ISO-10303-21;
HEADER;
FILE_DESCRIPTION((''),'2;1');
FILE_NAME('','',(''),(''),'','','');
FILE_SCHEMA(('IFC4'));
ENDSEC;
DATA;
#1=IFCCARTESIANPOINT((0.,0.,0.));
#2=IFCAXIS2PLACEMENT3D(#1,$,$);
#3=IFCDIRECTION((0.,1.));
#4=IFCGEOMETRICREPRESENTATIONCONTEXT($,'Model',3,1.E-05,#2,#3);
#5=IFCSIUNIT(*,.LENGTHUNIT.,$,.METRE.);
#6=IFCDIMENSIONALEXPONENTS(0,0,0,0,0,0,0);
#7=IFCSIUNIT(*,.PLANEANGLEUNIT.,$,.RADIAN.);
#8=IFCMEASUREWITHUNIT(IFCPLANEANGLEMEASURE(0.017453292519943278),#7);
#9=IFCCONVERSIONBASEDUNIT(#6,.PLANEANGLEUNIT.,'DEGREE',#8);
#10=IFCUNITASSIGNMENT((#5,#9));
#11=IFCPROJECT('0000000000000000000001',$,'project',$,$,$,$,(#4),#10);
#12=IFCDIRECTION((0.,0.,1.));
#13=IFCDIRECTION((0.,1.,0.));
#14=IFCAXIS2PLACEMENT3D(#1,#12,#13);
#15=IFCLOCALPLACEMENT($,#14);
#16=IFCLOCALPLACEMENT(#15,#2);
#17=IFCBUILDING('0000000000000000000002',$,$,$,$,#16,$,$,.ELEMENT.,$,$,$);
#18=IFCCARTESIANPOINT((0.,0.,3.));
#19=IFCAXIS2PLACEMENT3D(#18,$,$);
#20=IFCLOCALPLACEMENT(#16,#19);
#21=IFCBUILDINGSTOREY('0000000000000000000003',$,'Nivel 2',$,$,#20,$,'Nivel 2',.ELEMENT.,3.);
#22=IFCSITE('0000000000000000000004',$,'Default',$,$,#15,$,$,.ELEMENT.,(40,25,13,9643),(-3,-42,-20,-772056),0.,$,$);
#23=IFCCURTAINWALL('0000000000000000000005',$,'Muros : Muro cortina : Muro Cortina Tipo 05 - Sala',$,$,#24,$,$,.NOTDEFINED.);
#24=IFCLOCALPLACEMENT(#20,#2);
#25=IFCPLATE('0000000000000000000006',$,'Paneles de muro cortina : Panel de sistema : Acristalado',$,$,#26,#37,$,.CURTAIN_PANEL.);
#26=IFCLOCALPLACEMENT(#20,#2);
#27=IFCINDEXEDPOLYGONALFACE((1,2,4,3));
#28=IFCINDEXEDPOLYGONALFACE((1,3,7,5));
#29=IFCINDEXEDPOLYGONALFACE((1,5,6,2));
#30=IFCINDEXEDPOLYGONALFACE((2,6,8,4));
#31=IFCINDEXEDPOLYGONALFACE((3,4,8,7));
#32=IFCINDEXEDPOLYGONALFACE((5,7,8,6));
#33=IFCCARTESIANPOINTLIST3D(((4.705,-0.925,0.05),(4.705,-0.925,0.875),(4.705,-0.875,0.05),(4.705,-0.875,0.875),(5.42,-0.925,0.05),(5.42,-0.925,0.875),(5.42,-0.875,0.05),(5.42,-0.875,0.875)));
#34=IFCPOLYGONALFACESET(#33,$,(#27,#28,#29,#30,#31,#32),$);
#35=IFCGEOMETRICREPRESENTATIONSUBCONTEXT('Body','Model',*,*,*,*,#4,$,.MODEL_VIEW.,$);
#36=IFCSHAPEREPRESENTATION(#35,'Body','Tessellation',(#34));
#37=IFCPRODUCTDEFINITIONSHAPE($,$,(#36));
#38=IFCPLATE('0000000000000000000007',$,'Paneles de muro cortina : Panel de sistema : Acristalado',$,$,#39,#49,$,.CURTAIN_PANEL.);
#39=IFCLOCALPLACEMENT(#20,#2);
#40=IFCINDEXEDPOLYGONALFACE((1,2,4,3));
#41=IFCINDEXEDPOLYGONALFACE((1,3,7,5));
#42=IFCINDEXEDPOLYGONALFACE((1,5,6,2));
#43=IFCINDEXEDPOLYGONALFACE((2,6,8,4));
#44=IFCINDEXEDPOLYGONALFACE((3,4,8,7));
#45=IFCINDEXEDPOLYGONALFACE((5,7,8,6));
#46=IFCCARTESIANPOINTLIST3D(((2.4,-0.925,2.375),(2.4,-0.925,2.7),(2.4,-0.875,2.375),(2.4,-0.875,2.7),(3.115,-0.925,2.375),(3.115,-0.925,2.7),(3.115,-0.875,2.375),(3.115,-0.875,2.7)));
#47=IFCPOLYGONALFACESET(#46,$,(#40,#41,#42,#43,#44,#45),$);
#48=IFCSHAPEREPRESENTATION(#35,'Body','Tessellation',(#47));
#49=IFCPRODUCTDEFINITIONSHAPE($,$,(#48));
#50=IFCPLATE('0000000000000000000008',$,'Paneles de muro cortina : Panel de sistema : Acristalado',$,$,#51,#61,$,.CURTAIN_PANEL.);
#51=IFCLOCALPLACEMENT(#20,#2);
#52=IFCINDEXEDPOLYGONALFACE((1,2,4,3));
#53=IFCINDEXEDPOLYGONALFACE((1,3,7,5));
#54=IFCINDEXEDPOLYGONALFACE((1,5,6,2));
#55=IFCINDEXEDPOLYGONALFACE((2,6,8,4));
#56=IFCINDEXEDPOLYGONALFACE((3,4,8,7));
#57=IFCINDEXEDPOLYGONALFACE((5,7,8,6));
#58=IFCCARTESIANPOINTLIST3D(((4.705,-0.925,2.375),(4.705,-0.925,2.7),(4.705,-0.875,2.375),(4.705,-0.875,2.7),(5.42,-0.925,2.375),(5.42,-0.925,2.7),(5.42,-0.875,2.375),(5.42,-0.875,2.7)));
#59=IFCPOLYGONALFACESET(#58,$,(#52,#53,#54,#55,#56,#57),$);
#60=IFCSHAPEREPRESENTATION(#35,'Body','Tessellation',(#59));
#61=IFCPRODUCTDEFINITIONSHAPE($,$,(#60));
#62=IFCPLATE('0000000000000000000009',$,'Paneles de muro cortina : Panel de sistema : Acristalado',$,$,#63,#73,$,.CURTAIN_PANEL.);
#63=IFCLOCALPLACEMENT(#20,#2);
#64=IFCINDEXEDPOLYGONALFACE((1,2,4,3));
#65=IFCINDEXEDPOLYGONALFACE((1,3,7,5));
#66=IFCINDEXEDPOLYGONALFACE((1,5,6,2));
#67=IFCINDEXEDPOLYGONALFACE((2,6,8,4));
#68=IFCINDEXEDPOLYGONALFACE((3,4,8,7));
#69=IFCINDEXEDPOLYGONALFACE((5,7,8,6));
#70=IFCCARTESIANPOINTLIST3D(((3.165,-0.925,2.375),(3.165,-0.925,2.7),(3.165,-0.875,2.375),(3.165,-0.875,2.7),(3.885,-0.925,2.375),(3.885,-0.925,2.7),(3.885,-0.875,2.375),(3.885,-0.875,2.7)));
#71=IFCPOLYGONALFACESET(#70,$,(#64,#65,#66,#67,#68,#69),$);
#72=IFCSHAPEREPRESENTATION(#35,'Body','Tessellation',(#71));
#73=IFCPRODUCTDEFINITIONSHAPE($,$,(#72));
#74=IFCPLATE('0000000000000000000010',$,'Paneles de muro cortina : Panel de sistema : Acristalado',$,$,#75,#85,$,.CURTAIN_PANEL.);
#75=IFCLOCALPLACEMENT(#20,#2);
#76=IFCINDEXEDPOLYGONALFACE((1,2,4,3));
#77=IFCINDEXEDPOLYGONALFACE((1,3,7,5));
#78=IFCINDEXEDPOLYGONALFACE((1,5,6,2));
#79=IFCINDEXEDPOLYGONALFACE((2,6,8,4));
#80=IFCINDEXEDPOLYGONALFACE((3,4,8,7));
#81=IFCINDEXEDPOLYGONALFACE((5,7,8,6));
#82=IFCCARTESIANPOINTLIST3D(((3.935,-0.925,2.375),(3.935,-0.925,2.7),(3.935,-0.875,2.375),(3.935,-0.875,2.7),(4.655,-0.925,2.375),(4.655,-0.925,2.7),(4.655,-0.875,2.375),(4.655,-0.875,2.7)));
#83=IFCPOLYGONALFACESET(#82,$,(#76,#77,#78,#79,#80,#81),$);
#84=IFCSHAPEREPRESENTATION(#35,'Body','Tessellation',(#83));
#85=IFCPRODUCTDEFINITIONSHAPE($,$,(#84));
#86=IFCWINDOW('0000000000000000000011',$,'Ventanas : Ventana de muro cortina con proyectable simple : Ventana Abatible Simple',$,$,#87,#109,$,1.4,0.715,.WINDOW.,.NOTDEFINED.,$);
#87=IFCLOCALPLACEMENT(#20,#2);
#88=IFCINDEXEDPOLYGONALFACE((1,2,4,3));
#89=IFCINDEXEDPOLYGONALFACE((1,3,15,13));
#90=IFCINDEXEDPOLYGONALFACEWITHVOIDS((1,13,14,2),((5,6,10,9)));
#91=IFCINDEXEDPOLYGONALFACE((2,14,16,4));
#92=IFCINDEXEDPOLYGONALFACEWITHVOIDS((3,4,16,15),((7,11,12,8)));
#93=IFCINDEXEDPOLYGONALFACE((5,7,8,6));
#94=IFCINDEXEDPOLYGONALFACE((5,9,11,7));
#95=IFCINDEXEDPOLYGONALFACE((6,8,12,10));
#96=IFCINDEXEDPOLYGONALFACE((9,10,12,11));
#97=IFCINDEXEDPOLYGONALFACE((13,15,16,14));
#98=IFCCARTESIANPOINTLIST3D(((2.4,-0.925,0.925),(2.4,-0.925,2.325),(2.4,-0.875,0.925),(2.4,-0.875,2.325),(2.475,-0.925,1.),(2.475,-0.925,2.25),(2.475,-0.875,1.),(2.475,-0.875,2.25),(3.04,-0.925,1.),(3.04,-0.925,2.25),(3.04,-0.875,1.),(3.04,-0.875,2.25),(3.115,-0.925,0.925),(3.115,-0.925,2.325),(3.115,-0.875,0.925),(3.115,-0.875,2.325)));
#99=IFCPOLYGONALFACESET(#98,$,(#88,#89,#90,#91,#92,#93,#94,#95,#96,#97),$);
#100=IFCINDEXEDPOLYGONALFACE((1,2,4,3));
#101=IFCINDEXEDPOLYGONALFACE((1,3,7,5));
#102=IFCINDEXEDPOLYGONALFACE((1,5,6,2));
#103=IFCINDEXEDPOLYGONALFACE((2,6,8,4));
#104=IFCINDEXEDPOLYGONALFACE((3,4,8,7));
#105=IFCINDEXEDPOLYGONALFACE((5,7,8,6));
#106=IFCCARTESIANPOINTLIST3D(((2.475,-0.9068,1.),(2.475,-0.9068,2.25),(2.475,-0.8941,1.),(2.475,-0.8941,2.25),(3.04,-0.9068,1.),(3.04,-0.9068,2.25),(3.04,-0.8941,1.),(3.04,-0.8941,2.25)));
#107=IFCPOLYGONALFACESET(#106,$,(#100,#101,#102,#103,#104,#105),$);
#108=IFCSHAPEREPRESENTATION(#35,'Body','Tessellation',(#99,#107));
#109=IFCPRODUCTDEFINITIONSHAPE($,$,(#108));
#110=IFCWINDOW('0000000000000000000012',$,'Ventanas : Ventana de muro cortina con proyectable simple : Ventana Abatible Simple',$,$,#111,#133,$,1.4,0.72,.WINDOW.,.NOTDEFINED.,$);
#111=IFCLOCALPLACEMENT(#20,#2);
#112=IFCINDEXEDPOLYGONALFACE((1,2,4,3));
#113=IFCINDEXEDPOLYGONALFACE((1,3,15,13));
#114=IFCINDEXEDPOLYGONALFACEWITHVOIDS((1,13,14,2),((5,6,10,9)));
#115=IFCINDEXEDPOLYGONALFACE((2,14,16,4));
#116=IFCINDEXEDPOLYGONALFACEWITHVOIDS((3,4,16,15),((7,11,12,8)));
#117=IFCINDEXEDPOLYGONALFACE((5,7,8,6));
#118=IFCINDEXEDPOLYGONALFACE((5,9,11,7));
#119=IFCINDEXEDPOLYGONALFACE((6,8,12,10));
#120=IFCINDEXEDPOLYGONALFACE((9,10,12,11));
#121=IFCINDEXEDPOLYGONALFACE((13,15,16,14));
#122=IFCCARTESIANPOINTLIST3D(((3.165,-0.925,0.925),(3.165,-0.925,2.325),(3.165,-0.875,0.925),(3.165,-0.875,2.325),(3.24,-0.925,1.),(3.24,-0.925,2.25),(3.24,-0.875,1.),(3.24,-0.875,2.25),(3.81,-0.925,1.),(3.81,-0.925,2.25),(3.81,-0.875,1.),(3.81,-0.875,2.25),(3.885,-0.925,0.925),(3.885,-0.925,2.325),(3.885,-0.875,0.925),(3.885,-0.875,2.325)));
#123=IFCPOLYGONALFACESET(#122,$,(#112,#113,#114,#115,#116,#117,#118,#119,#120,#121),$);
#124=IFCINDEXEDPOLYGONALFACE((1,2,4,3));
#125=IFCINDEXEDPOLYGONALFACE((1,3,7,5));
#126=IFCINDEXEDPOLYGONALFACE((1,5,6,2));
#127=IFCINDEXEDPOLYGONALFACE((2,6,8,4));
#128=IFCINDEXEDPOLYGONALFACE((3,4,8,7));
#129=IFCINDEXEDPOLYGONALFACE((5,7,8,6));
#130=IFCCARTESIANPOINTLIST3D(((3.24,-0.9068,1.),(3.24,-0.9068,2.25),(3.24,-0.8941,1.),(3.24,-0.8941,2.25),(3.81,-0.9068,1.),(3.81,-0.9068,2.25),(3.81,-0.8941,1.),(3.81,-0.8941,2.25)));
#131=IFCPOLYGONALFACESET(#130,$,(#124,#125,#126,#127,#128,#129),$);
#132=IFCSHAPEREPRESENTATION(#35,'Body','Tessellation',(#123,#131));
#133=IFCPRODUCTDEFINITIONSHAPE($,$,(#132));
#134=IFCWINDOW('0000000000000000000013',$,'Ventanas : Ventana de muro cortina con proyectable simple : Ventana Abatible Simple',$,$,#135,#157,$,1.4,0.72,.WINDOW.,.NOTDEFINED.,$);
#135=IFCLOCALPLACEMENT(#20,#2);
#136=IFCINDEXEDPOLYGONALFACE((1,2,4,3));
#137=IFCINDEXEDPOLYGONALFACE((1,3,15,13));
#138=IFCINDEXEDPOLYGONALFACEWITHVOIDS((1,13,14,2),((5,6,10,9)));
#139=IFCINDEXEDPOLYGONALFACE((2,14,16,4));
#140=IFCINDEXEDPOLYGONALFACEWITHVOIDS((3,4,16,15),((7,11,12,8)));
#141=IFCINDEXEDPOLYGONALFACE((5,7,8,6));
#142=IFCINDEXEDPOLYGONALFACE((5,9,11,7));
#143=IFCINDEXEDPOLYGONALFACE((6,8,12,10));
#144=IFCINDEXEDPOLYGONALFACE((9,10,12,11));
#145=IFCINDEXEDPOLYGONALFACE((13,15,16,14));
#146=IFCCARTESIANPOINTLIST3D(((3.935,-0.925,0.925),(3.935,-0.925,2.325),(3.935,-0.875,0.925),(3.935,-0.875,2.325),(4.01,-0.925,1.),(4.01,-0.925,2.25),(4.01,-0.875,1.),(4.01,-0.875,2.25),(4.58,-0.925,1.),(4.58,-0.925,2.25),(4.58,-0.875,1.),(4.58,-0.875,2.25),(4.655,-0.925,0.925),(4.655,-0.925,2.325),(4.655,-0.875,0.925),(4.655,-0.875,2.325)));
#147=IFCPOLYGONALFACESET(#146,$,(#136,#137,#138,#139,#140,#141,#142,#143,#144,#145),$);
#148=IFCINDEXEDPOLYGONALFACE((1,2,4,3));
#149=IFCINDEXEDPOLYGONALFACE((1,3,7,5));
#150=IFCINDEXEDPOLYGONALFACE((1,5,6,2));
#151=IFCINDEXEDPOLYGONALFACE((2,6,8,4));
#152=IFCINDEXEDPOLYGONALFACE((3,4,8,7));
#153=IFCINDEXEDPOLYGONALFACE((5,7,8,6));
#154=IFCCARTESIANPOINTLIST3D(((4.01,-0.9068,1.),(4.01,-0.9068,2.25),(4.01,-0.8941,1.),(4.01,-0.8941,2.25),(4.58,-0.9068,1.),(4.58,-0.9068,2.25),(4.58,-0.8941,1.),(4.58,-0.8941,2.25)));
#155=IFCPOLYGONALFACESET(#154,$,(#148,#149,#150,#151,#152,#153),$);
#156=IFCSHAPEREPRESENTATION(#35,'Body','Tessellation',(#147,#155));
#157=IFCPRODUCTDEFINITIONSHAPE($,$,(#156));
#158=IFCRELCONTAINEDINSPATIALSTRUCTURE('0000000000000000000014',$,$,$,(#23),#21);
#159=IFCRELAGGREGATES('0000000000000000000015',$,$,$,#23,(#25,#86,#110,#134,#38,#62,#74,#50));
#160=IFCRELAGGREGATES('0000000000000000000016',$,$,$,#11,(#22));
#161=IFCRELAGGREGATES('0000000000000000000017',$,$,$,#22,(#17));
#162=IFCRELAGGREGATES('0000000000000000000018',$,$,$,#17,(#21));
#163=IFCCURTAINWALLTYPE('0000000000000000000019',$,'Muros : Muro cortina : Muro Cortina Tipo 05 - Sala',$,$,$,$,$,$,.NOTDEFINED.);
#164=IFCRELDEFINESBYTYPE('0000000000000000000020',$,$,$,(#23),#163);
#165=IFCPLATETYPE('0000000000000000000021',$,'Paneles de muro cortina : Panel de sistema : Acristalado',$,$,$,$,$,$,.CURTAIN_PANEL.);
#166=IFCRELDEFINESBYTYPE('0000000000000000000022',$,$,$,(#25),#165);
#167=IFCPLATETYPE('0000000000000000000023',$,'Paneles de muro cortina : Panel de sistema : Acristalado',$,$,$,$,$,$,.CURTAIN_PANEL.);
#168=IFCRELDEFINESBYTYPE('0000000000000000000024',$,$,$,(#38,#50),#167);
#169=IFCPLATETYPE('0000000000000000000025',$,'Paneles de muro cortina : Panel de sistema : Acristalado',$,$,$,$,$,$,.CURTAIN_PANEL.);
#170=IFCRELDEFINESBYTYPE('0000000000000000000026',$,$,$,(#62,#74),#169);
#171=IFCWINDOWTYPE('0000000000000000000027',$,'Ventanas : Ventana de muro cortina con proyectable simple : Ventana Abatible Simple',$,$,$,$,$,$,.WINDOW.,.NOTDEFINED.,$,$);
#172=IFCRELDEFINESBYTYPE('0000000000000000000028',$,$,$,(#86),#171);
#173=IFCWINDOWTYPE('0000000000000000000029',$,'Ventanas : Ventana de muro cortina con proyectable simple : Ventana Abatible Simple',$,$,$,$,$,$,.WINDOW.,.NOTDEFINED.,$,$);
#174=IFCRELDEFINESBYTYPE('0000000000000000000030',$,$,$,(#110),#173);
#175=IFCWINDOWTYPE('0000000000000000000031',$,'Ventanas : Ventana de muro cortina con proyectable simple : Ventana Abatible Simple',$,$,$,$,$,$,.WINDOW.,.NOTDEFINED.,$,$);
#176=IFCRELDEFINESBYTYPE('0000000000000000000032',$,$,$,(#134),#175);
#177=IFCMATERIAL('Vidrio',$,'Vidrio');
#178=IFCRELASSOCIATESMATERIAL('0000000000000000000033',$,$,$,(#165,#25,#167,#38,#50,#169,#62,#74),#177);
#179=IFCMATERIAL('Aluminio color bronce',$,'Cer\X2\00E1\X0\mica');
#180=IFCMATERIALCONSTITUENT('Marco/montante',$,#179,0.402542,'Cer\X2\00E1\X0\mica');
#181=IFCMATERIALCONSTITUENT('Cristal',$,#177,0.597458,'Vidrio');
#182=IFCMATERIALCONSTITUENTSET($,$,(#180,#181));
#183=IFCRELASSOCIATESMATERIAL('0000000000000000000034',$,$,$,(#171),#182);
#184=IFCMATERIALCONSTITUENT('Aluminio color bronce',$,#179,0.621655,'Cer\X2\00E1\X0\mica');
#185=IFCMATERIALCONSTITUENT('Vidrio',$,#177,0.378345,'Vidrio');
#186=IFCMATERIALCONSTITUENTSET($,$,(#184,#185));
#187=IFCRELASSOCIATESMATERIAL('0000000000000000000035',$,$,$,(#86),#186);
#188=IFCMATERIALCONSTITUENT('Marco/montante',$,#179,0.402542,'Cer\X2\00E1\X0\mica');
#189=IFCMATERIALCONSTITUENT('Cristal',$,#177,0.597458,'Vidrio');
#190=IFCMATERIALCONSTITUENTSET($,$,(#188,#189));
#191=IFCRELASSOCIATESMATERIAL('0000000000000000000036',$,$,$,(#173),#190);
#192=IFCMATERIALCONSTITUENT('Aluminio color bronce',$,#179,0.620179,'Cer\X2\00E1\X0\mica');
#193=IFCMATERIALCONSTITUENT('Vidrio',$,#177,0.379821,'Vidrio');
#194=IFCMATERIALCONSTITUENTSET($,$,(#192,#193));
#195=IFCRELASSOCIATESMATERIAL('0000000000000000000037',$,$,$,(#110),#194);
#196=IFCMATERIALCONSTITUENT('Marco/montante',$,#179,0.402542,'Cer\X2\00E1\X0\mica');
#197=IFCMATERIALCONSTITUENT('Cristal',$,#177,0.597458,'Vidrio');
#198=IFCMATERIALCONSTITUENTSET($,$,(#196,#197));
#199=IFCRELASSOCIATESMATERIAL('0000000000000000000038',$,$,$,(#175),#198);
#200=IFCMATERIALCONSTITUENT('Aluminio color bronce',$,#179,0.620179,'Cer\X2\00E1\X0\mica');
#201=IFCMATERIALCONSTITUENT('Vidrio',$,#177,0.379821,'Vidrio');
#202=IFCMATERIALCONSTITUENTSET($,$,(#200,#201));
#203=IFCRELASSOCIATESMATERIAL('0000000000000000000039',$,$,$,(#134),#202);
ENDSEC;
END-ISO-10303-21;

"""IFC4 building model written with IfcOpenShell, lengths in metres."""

from ifc_helpers import new_model, entity, si_unit, converted_unit, direction, frame, origin, place, context, subcontext, project, spatial, indexed_curve, outline, extrude, source, transform, mapped, material, constituent, constituent_set, type_object, type_shapes, element, aggregate, save


model = new_model("IFC4")

# Units and contexts
model_context = context("Model", 3, precision=1e-05, world=origin(), true_north=direction((0.0, 1.0)))
body_context = subcontext(model_context, "Body", "Model", "MODEL_VIEW")
ifc_project = project(units=[si_unit("LENGTHUNIT", "METRE"), converted_unit("PLANEANGLEUNIT", "DEGREE", entity("IfcPlaneAngleMeasure", 0.017453292519943278), si_unit("PLANEANGLEUNIT", "RADIAN"), dimensions=[0, 0, 0, 0, 0, 0, 0])], contexts=[model_context])

# Site, building, storey
site_placement = place(None, frame((0.0, 0.0, 0.0), z_axis=(0.0, 0.0, 1.0), x_axis=(0.0, 1.0, 0.0)))
site = spatial("IfcSite", under=ifc_project, at=site_placement, Name="Default", CompositionType="ELEMENT", RefLatitude=(40, 25, 13, 9643), RefLongitude=(-3, -42, -20, -772056), RefElevation=0.0)
building_placement = place(site_placement, origin())
building = spatial("IfcBuilding", under=site, at=building_placement, CompositionType="ELEMENT")
storey_placement = place(building_placement, frame((0.0, 0.0, 3.0)))
storey = spatial("IfcBuildingStorey", under=building, at=storey_placement, Name="Nivel 2", LongName="Nivel 2", CompositionType="ELEMENT", Elevation=3.0)

# Curtain wall, plates, windows
curtain_wall_type = type_object("IfcCurtainWallType", Name="Muros : Muro cortina : Muro Cortina Tipo 05 - Sala", PredefinedType="NOTDEFINED")
curtain_wall_placement = place(storey_placement, frame((0.0, 0.0, -3.0)))
curtain_wall = element("IfcCurtainWall", 1, at=curtain_wall_placement, inside=storey, type_object=curtain_wall_type, Name="Muros : Muro cortina : Muro Cortina Tipo 05 - Sala", PredefinedType="NOTDEFINED")
ifc_material_1 = material(Name="Aluminio color bronce", Category="Cerámica")
ifc_material_2 = material(Name="Vidrio", Category="Vidrio")
plate_type_1 = type_object("IfcPlateType", Name="Paneles de muro cortina : Panel de sistema : Acristalado", PredefinedType="CURTAIN_PANEL", material=ifc_material_2)
shared_shape_1 = source(origin(), body_context, "Body", "SweptSolid", [
    extrude(outline(indexed_curve([(-0.025, -0.3575), (0.025, -0.3575), (0.025, 0.3575), (-0.025, 0.3575), (-0.025, -0.3575)], self_intersect=False)), frame((0.0, 0.0, 0.0), z_axis=(0.0, 0.0, 1.0), x_axis=(0.0, 1.0, 0.0)), (0.0, 0.0, 1.0), 0.825),
])
type_shapes(plate_type_1, [shared_shape_1])
plate_1_placement = place(curtain_wall_placement, frame((5.0625, -0.9, 3.05)))
plate_1 = element("IfcPlate", 2, at=plate_1_placement, type_object=plate_type_1, material=ifc_material_2, Name="Paneles de muro cortina : Panel de sistema : Acristalado", PredefinedType="CURTAIN_PANEL", context=body_context, shape_type="MappedRepresentation", body=[
    mapped(shared_shape_1, transform((0.0, 0.0, 0.0), scale=1.0)),
])
plate_type_2 = type_object("IfcPlateType", Name="Paneles de muro cortina : Panel de sistema : Acristalado", PredefinedType="CURTAIN_PANEL", material=ifc_material_2)
shared_shape_2 = source(origin(), body_context, "Body", "SweptSolid", [
    extrude(outline(indexed_curve([(-0.025, -0.3575), (0.025, -0.3575), (0.025, 0.3575), (-0.025, 0.3575), (-0.025, -0.3575)], self_intersect=False)), frame((0.0, 0.0, 0.0), z_axis=(0.0, 0.0, 1.0), x_axis=(0.0, 1.0, 0.0)), (0.0, 0.0, 1.0), 0.325),
])
type_shapes(plate_type_2, [shared_shape_2])
plate_2_placement = place(curtain_wall_placement, frame((2.7575, -0.9, 5.375)))
plate_2 = element("IfcPlate", 3, at=plate_2_placement, type_object=plate_type_2, material=ifc_material_2, Name="Paneles de muro cortina : Panel de sistema : Acristalado", PredefinedType="CURTAIN_PANEL", context=body_context, shape_type="MappedRepresentation", body=[
    mapped(shared_shape_2, transform((0.0, 0.0, 0.0), scale=1.0)),
])
plate_3_placement = place(curtain_wall_placement, frame((5.0625, -0.9, 5.375)))
plate_3 = element("IfcPlate", 4, at=plate_3_placement, type_object=plate_type_2, material=ifc_material_2, Name="Paneles de muro cortina : Panel de sistema : Acristalado", PredefinedType="CURTAIN_PANEL", context=body_context, shape_type="MappedRepresentation", body=[
    mapped(shared_shape_2, transform((0.0, 0.0, 0.0), scale=1.0)),
])
plate_type_3 = type_object("IfcPlateType", Name="Paneles de muro cortina : Panel de sistema : Acristalado", PredefinedType="CURTAIN_PANEL", material=ifc_material_2)
shared_shape_3 = source(origin(), body_context, "Body", "SweptSolid", [
    extrude(outline(indexed_curve([(-0.025, -0.36), (0.025, -0.36), (0.025, 0.36), (-0.025, 0.36), (-0.025, -0.36)], self_intersect=False)), frame((0.0, 0.0, 0.0), z_axis=(0.0, 0.0, 1.0), x_axis=(0.0, 1.0, 0.0)), (0.0, 0.0, 1.0), 0.325),
])
type_shapes(plate_type_3, [shared_shape_3])
plate_4_placement = place(curtain_wall_placement, frame((3.525, -0.9, 5.375)))
plate_4 = element("IfcPlate", 5, at=plate_4_placement, type_object=plate_type_3, material=ifc_material_2, Name="Paneles de muro cortina : Panel de sistema : Acristalado", PredefinedType="CURTAIN_PANEL", context=body_context, shape_type="MappedRepresentation", body=[
    mapped(shared_shape_3, transform((0.0, 0.0, 0.0), scale=1.0)),
])
plate_5_placement = place(curtain_wall_placement, frame((4.295, -0.9, 5.375)))
plate_5 = element("IfcPlate", 6, at=plate_5_placement, type_object=plate_type_3, material=ifc_material_2, Name="Paneles de muro cortina : Panel de sistema : Acristalado", PredefinedType="CURTAIN_PANEL", context=body_context, shape_type="MappedRepresentation", body=[
    mapped(shared_shape_3, transform((0.0, 0.0, 0.0), scale=1.0)),
])
ifc_constituent_1 = constituent(ifc_material_1, Name="Aluminio color bronce", Category="Cerámica", fraction=0.621655)
ifc_constituent_2 = constituent(ifc_material_2, Name="Vidrio", Category="Vidrio", fraction=0.378345)
ifc_constituent_set_1 = constituent_set(constituents=[ifc_constituent_1, ifc_constituent_2])
ifc_constituent_3 = constituent(ifc_material_1, Name="Marco/montante", Category="Cerámica", fraction=0.402542)
ifc_constituent_4 = constituent(ifc_material_2, Name="Cristal", Category="Vidrio", fraction=0.597458)
ifc_constituent_set_2 = constituent_set(constituents=[ifc_constituent_3, ifc_constituent_4])
window_type_1 = type_object("IfcWindowType", Name="Ventanas : Ventana de muro cortina con proyectable simple : Ventana Abatible Simple", PartitioningType="NOTDEFINED", PredefinedType="WINDOW", material=ifc_constituent_set_2)
shared_shape_4 = source(origin(), body_context, "Body", "SweptSolid", [
    extrude(outline(indexed_curve([(-0.3575, -0.7), (0.3575, -0.7), (0.3575, 0.7), (-0.3575, 0.7), (-0.3575, -0.7)], self_intersect=False), holes=[indexed_curve([(-0.2825, -0.625), (-0.2825, 0.625), (0.2825, 0.625), (0.2825, -0.625), (-0.2825, -0.625)], self_intersect=False)]), frame((0.0, 0.025, 0.7), z_axis=(0.0, -1.0, 0.0), x_axis=(-1.0, 0.0, 0.0)), (0.0, 0.0, 1.0), 0.05),
    extrude(outline(indexed_curve([(-0.2825, -0.0063), (0.2825, -0.0063), (0.2825, 0.0063), (-0.2825, 0.0063), (-0.2825, -0.0063)], self_intersect=False)), frame((0.0, 0.0004, 0.075)), (0.0, 0.0, 1.0), 1.25),
])
type_shapes(window_type_1, [shared_shape_4])
window_1_placement = place(curtain_wall_placement, frame((2.7575, -0.9, 3.925), z_axis=(0.0, 0.0, 1.0), x_axis=(-1.0, 0.0, 0.0)))
window_1 = element("IfcWindow", 7, at=window_1_placement, type_object=window_type_1, material=ifc_constituent_set_1, Name="Ventanas : Ventana de muro cortina con proyectable simple : Ventana Abatible Simple", OverallHeight=1.4, OverallWidth=0.715, PartitioningType="NOTDEFINED", PredefinedType="WINDOW", context=body_context, shape_type="MappedRepresentation", body=[
    mapped(shared_shape_4, transform((0.0, 0.0, 0.0), scale=1.0)),
])
ifc_constituent_5 = constituent(ifc_material_1, Name="Aluminio color bronce", Category="Cerámica", fraction=0.620179)
ifc_constituent_6 = constituent(ifc_material_2, Name="Vidrio", Category="Vidrio", fraction=0.379821)
ifc_constituent_set_3 = constituent_set(constituents=[ifc_constituent_5, ifc_constituent_6])
ifc_constituent_7 = constituent(ifc_material_1, Name="Marco/montante", Category="Cerámica", fraction=0.402542)
ifc_constituent_8 = constituent(ifc_material_2, Name="Cristal", Category="Vidrio", fraction=0.597458)
ifc_constituent_set_4 = constituent_set(constituents=[ifc_constituent_7, ifc_constituent_8])
window_type_2 = type_object("IfcWindowType", Name="Ventanas : Ventana de muro cortina con proyectable simple : Ventana Abatible Simple", PartitioningType="NOTDEFINED", PredefinedType="WINDOW", material=ifc_constituent_set_4)
shared_shape_5 = source(origin(), body_context, "Body", "SweptSolid", [
    extrude(outline(indexed_curve([(-0.36, -0.7), (0.36, -0.7), (0.36, 0.7), (-0.36, 0.7), (-0.36, -0.7)], self_intersect=False), holes=[indexed_curve([(-0.285, -0.625), (-0.285, 0.625), (0.285, 0.625), (0.285, -0.625), (-0.285, -0.625)], self_intersect=False)]), frame((0.0, -0.025, 0.7), z_axis=(0.0, 1.0, 0.0), x_axis=(1.0, 0.0, 0.0)), (0.0, 0.0, 1.0), 0.05),
    extrude(outline(indexed_curve([(-0.0063, -0.285), (0.0063, -0.285), (0.0063, 0.285), (-0.0063, 0.285), (-0.0063, -0.285)], self_intersect=False)), frame((0.0, 0.0004, 0.075), z_axis=(0.0, 0.0, 1.0), x_axis=(0.0, 1.0, 0.0)), (0.0, 0.0, 1.0), 1.25),
])
type_shapes(window_type_2, [shared_shape_5])
window_2_placement = place(curtain_wall_placement, frame((3.525, -0.9, 3.925), z_axis=(0.0, 0.0, 1.0), x_axis=(-1.0, 0.0, 0.0)))
window_2 = element("IfcWindow", 8, at=window_2_placement, type_object=window_type_2, material=ifc_constituent_set_3, Name="Ventanas : Ventana de muro cortina con proyectable simple : Ventana Abatible Simple", OverallHeight=1.4, OverallWidth=0.72, PartitioningType="NOTDEFINED", PredefinedType="WINDOW", context=body_context, shape_type="MappedRepresentation", body=[
    mapped(shared_shape_5, transform((0.0, 0.0, 0.0), scale=1.0)),
])
ifc_constituent_9 = constituent(ifc_material_1, Name="Aluminio color bronce", Category="Cerámica", fraction=0.620179)
ifc_constituent_10 = constituent(ifc_material_2, Name="Vidrio", Category="Vidrio", fraction=0.379821)
ifc_constituent_set_5 = constituent_set(constituents=[ifc_constituent_9, ifc_constituent_10])
ifc_constituent_11 = constituent(ifc_material_1, Name="Marco/montante", Category="Cerámica", fraction=0.402542)
ifc_constituent_12 = constituent(ifc_material_2, Name="Cristal", Category="Vidrio", fraction=0.597458)
ifc_constituent_set_6 = constituent_set(constituents=[ifc_constituent_11, ifc_constituent_12])
window_type_3 = type_object("IfcWindowType", Name="Ventanas : Ventana de muro cortina con proyectable simple : Ventana Abatible Simple", PartitioningType="NOTDEFINED", PredefinedType="WINDOW", material=ifc_constituent_set_6)
shared_shape_6 = source(origin(), body_context, "Body", "SweptSolid", [
    extrude(outline(indexed_curve([(-0.36, -0.7), (0.36, -0.7), (0.36, 0.7), (-0.36, 0.7), (-0.36, -0.7)], self_intersect=False), holes=[indexed_curve([(-0.285, -0.625), (-0.285, 0.625), (0.285, 0.625), (0.285, -0.625), (-0.285, -0.625)], self_intersect=False)]), frame((0.0, 0.025, 0.7), z_axis=(0.0, -1.0, 0.0), x_axis=(-1.0, 0.0, 0.0)), (0.0, 0.0, 1.0), 0.05),
    extrude(outline(indexed_curve([(-0.285, -0.0063), (0.285, -0.0063), (0.285, 0.0063), (-0.285, 0.0063), (-0.285, -0.0063)], self_intersect=False)), frame((0.0, 0.0004, 0.075)), (0.0, 0.0, 1.0), 1.25),
])
type_shapes(window_type_3, [shared_shape_6])
window_3_placement = place(curtain_wall_placement, frame((4.295, -0.9, 3.925), z_axis=(0.0, 0.0, 1.0), x_axis=(-1.0, 0.0, 0.0)))
window_3 = element("IfcWindow", 9, at=window_3_placement, type_object=window_type_3, material=ifc_constituent_set_5, Name="Ventanas : Ventana de muro cortina con proyectable simple : Ventana Abatible Simple", OverallHeight=1.4, OverallWidth=0.72, PartitioningType="NOTDEFINED", PredefinedType="WINDOW", context=body_context, shape_type="MappedRepresentation", body=[
    mapped(shared_shape_6, transform((0.0, 0.0, 0.0), scale=1.0)),
])
aggregate(curtain_wall, [plate_1, window_1, window_2, window_3, plate_2, plate_4, plate_5, plate_3])

save(model, "model.ifc")
